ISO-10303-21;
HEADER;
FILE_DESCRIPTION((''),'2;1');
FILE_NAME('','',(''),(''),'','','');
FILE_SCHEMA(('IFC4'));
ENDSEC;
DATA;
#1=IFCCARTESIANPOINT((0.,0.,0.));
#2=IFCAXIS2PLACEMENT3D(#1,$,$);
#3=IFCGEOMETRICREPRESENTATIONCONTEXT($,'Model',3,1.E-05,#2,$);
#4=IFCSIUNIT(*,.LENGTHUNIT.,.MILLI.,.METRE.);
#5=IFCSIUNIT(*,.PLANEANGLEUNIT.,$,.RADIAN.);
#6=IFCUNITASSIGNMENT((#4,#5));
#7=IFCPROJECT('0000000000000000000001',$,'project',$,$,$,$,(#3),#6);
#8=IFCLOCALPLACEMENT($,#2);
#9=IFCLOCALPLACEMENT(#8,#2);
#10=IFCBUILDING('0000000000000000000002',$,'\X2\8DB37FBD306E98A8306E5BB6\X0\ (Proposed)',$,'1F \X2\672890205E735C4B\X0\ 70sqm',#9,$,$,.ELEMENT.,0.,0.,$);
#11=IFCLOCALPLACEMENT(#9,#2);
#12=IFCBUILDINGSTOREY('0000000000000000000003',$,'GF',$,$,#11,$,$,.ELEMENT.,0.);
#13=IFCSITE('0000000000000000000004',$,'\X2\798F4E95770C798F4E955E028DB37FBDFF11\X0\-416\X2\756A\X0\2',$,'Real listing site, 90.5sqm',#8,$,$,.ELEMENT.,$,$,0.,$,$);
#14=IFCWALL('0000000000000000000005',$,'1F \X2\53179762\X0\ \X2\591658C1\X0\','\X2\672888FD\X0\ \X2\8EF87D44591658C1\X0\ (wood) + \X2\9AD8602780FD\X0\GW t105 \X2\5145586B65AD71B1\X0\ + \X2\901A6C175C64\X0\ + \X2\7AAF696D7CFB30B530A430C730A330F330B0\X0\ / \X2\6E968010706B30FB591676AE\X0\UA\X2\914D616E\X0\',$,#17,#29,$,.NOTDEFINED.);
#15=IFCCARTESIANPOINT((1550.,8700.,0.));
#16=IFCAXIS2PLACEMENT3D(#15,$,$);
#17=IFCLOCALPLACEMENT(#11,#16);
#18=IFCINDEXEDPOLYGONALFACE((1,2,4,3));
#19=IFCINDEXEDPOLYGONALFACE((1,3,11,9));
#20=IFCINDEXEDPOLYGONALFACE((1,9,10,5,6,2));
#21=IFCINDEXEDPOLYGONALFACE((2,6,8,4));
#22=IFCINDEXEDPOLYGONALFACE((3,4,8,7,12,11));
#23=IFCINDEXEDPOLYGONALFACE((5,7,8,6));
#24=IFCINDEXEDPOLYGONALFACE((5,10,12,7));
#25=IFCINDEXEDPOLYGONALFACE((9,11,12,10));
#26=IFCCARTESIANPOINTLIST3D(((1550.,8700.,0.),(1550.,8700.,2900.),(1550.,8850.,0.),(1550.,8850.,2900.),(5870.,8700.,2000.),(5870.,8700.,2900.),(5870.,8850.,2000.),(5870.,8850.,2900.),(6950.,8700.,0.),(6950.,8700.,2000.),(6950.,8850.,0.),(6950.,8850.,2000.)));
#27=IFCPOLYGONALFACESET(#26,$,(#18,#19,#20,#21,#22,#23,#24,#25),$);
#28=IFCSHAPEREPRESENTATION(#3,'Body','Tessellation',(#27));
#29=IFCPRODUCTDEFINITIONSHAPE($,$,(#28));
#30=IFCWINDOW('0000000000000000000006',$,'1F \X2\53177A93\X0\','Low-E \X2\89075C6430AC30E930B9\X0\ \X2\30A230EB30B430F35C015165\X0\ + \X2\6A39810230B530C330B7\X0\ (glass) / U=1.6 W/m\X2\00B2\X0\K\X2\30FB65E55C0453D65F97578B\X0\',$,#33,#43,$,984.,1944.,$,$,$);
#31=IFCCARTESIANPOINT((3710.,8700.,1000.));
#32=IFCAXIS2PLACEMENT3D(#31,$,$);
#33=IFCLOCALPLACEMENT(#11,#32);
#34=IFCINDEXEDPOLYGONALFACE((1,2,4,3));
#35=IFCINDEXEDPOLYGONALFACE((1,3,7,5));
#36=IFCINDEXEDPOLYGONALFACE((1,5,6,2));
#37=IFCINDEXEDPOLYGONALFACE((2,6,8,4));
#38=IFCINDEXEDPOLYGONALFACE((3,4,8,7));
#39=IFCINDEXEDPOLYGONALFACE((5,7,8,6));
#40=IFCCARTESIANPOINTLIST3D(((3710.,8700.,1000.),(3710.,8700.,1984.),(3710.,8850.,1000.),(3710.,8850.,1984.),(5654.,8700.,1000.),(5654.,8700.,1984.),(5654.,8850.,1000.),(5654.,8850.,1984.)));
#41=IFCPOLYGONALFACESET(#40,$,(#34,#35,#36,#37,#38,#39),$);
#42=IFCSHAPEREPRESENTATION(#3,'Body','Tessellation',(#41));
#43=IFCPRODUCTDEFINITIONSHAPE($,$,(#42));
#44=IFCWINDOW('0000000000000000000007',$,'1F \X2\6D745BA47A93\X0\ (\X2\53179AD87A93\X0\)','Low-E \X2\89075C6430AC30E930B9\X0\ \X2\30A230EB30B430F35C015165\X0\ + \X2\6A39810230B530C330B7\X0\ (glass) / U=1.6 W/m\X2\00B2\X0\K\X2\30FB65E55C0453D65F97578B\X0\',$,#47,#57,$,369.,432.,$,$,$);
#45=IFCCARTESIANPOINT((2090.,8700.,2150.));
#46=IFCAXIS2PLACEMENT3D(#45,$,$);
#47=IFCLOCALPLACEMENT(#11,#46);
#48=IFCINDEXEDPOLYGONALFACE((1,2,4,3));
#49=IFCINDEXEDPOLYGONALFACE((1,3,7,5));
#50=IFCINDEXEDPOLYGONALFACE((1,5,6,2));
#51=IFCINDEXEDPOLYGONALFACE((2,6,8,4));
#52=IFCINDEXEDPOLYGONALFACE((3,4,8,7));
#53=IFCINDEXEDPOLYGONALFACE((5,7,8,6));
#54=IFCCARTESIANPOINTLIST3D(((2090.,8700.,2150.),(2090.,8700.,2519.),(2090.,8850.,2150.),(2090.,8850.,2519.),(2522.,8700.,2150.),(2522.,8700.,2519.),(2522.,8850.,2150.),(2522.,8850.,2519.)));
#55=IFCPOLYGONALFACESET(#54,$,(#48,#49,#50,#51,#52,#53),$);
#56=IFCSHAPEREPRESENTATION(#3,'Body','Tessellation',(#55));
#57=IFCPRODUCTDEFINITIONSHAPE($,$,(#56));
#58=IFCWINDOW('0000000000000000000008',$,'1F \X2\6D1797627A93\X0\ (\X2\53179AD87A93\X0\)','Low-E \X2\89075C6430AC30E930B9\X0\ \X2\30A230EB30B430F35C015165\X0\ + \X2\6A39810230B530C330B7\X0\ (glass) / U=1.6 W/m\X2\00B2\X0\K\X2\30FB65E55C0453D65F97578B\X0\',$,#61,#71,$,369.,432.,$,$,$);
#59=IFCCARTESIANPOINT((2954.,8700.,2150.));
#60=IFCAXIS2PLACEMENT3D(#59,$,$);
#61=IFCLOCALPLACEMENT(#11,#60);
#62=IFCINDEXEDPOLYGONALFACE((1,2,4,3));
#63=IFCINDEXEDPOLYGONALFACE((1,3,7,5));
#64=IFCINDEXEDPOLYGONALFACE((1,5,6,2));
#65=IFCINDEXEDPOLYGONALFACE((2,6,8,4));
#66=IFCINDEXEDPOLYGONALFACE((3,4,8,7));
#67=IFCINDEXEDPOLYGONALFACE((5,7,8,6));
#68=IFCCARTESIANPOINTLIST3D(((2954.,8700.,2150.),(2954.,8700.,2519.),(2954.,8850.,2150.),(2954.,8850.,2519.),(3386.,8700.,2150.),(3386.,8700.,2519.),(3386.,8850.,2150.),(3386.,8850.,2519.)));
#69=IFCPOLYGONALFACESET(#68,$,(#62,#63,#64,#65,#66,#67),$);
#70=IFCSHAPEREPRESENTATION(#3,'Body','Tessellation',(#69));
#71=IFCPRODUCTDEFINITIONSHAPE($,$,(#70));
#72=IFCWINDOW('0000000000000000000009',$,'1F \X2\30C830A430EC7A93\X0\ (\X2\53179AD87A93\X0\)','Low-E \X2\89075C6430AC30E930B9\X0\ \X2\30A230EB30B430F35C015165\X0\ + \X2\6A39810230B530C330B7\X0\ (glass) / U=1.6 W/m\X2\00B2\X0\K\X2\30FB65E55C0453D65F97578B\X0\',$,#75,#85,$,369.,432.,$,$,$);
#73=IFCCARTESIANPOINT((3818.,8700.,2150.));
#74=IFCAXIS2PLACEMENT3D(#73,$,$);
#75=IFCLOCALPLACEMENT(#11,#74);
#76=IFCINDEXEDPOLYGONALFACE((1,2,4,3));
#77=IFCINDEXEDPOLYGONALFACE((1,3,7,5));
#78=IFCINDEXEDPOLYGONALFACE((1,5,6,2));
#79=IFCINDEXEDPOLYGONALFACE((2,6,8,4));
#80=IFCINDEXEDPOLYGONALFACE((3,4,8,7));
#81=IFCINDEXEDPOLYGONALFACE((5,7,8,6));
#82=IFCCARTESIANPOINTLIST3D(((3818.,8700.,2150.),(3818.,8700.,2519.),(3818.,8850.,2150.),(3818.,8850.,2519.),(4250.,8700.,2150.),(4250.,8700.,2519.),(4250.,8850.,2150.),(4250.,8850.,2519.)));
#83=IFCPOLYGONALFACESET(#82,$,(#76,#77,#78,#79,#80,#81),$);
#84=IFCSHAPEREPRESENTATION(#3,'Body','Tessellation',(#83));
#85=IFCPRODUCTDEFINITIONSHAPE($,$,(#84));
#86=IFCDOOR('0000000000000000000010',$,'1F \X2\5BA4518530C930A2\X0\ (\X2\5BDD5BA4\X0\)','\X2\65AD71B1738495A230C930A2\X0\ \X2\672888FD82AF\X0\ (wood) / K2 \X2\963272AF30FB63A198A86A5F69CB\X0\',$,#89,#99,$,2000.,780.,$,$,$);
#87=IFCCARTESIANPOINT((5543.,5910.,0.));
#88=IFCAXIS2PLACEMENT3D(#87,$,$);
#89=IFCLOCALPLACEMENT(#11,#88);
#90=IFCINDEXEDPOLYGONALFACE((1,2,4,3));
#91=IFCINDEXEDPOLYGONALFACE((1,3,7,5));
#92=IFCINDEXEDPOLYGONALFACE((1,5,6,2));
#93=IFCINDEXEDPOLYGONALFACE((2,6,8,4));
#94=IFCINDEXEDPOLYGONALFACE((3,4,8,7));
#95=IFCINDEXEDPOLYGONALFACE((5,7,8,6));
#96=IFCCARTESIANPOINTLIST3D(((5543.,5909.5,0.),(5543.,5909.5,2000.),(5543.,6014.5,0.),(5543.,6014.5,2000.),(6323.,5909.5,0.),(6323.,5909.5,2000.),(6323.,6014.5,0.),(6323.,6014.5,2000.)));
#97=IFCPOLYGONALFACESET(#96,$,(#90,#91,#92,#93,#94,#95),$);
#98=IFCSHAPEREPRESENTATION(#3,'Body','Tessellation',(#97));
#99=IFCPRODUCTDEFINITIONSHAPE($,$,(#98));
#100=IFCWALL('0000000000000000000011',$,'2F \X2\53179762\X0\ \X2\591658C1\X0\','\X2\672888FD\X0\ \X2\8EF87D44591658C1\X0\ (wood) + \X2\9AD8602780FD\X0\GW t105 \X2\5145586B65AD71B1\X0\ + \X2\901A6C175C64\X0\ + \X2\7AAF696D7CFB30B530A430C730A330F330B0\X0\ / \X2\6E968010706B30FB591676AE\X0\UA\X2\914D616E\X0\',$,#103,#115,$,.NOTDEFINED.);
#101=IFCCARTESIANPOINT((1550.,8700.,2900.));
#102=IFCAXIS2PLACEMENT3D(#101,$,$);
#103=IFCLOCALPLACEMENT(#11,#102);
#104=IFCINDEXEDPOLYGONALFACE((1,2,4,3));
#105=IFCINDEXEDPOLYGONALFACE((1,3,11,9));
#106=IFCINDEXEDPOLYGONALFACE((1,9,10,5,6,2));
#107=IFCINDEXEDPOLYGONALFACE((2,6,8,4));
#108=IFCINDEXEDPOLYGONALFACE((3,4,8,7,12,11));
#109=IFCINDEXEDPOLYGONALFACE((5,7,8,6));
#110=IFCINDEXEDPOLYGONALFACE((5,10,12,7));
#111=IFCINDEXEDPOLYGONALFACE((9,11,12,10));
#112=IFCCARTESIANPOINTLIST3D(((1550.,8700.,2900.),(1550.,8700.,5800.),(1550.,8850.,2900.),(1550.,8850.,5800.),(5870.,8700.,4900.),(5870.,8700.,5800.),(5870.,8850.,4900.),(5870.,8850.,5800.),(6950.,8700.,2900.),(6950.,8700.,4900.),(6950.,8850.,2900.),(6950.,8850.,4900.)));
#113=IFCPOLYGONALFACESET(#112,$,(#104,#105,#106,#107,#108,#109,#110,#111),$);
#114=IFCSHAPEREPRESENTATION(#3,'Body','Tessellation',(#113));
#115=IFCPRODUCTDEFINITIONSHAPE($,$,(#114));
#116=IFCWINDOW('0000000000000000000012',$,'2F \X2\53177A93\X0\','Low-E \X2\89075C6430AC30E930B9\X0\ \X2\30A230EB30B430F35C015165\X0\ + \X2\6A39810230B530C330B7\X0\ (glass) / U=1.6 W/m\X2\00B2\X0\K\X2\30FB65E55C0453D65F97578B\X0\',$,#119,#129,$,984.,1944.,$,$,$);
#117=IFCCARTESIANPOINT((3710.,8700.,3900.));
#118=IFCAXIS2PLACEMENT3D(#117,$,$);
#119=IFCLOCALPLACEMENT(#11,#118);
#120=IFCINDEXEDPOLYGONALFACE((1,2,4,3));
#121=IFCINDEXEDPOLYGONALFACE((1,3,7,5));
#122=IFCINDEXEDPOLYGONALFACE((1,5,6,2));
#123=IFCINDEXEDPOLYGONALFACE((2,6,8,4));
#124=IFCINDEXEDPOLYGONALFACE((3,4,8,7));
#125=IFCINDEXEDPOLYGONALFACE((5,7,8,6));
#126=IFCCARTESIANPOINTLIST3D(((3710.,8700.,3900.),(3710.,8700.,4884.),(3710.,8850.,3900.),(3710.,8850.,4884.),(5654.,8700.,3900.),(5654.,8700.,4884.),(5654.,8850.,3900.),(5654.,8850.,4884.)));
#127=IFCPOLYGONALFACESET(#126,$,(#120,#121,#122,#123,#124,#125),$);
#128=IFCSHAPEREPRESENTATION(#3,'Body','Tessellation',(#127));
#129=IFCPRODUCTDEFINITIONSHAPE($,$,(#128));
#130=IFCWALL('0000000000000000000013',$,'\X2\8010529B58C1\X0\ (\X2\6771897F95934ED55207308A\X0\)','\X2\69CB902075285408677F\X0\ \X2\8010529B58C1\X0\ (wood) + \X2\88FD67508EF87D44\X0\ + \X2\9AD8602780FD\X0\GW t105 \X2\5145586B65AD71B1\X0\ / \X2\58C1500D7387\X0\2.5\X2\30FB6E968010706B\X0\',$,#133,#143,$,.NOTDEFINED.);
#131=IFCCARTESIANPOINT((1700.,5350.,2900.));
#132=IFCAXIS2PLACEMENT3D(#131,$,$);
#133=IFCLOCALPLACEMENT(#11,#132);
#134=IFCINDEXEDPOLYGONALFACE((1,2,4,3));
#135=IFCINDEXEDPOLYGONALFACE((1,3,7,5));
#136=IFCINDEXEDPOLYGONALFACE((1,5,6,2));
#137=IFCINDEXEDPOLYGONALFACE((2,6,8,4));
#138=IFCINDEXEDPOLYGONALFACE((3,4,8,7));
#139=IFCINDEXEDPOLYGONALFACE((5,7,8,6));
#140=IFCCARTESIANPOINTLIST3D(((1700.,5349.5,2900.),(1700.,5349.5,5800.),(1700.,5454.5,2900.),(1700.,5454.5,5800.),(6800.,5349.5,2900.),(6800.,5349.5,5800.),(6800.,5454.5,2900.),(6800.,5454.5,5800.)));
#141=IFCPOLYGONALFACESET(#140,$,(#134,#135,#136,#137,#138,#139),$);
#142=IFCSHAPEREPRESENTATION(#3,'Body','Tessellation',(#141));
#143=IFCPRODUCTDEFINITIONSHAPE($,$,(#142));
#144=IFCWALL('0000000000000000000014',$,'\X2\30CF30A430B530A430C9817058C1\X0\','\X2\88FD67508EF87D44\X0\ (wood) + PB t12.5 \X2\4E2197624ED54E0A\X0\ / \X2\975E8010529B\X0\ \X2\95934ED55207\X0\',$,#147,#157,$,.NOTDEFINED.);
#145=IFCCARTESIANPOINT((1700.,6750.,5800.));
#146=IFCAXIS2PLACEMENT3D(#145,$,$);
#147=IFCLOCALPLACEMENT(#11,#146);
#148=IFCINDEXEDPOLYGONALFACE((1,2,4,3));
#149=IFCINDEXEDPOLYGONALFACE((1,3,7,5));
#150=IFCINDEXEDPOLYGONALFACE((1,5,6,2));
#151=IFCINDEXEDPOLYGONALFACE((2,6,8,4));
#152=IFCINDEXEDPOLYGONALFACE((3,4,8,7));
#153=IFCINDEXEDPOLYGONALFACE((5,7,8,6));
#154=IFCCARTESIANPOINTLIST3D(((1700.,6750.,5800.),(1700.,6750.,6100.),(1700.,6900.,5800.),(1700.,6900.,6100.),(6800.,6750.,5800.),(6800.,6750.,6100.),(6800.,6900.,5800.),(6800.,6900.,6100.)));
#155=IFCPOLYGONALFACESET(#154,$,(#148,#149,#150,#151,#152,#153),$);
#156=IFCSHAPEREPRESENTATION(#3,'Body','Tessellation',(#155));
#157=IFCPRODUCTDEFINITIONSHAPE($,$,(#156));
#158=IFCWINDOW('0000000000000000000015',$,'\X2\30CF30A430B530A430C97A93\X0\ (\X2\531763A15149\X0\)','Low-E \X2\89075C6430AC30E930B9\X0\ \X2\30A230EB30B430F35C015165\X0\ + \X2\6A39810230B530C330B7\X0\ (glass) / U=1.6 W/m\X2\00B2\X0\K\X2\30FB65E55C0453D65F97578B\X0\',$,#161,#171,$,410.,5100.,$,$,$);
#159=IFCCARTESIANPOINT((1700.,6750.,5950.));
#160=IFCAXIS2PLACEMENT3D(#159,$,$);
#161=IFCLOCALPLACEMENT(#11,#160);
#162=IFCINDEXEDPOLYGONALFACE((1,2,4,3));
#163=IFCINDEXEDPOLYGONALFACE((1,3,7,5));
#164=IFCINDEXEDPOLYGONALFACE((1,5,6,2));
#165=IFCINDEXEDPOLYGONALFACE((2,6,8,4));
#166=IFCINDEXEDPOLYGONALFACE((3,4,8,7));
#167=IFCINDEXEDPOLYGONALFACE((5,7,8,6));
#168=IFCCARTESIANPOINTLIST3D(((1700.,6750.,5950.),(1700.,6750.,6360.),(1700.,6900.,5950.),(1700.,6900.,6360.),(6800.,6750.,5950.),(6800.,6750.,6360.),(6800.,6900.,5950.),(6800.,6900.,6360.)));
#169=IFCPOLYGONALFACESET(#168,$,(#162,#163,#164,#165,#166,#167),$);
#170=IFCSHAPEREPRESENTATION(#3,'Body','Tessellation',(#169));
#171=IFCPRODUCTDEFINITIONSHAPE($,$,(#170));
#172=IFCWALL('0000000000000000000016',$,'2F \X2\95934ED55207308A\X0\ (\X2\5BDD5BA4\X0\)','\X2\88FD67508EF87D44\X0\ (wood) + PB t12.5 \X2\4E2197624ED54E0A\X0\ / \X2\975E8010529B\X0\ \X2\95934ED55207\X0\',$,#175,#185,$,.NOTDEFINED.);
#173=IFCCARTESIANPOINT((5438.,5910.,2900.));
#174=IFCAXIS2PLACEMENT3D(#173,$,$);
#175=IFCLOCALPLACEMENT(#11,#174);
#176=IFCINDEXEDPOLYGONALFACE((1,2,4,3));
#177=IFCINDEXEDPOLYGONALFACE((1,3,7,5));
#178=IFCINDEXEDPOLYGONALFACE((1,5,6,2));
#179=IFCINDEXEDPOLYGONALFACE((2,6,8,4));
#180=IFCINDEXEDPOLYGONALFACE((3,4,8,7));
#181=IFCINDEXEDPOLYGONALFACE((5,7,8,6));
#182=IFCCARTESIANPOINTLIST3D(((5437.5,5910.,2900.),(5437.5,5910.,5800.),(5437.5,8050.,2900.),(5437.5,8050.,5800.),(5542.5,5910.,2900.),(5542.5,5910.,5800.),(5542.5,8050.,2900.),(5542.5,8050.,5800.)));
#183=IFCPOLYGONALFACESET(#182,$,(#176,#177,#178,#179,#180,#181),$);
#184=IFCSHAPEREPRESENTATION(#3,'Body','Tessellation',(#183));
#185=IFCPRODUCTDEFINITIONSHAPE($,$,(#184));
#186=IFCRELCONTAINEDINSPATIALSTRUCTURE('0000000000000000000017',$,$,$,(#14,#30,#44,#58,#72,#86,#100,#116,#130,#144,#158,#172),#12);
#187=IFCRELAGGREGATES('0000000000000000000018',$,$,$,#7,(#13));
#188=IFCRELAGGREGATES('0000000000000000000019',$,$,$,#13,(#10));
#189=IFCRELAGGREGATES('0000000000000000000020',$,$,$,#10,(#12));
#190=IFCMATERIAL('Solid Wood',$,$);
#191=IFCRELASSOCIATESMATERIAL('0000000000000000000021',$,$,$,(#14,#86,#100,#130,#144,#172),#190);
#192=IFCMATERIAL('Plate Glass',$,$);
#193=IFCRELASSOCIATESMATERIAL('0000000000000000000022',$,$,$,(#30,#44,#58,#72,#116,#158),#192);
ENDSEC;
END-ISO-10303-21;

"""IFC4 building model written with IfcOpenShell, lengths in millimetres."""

from ifc_helpers import new_model, si_unit, frame, frame_2d, origin, place, context, project, spatial, rectangle, extrude, material, element, fill, save


model = new_model("IFC4")

# Units and contexts
model_context = context("Model", 3, precision=1e-05, world=origin())
ifc_project = project(units=[si_unit("LENGTHUNIT", "METRE", prefix="MILLI"), si_unit("PLANEANGLEUNIT", "RADIAN")], contexts=[model_context])

# Site, building, storey
site_placement = place(None, origin())
site = spatial("IfcSite", under=ifc_project, at=site_placement, Name="福井県福井市足羽１-416番2", ObjectType="Real listing site, 90.5sqm", CompositionType="ELEMENT", RefElevation=0.0)
building_placement = place(site_placement, origin())
building = spatial("IfcBuilding", under=site, at=building_placement, Name="足羽の風の家 (Proposed)", ObjectType="1F 木造平屋 70sqm", CompositionType="ELEMENT", ElevationOfRefHeight=0.0, ElevationOfTerrain=0.0)
storey_placement = place(building_placement, origin())
storey = spatial("IfcBuildingStorey", under=building, at=storey_placement, Name="GF", CompositionType="ELEMENT", Elevation=0.0)

# Wall, openings, windows
ifc_material_1 = material(Name="Solid Wood")
wall_1_placement = place(storey_placement, frame((1550.0, 8700.0, 0.0)))
wall_1 = element("IfcWall", 1, at=wall_1_placement, inside=storey, material=ifc_material_1, Name="1F 北面 外壁", Description="木製 軸組外壁 (wood) + 高性能GW t105 充填断熱 + 通気層 + 窯業系サイディング / 準耐火・外皮UA配慮", PredefinedType="NOTDEFINED", context=model_context, shape_type="SweptSolid", body=[
    extrude(rectangle(XDim=5400.0, YDim=150.0, at=frame_2d((2700.0, 75.0))), frame((1550.0, 8700.0, 0.0)), (0.0, 0.0, 1.0), 2900.0),
])
opening_1_placement = place(storey_placement, frame((3710.0, 8700.0, 1000.0)))
opening_1 = element("IfcOpeningElement", 2, at=opening_1_placement, cuts=wall_1, PredefinedType="NOTDEFINED", context=model_context, shape_type="SweptSolid", body=[
    extrude(rectangle(XDim=1944.0, YDim=150.0, at=frame_2d((972.0, 75.0))), frame((3710.0, 8700.0, 1000.0)), (0.0, 0.0, 1.0), 984.0),
])
opening_2_placement = place(storey_placement, frame((2090.0, 8700.0, 2150.0)))
opening_2 = element("IfcOpeningElement", 3, at=opening_2_placement, cuts=wall_1, PredefinedType="NOTDEFINED", context=model_context, shape_type="SweptSolid", body=[
    extrude(rectangle(XDim=432.0, YDim=150.0, at=frame_2d((216.0, 75.0))), frame((2090.0, 8700.0, 2150.0)), (0.0, 0.0, 1.0), 369.0),
])
opening_3_placement = place(storey_placement, frame((2954.0, 8700.0, 2150.0)))
opening_3 = element("IfcOpeningElement", 4, at=opening_3_placement, cuts=wall_1, PredefinedType="NOTDEFINED", context=model_context, shape_type="SweptSolid", body=[
    extrude(rectangle(XDim=432.0, YDim=150.0, at=frame_2d((216.0, 75.0))), frame((2954.0, 8700.0, 2150.0)), (0.0, 0.0, 1.0), 369.0),
])
opening_4_placement = place(storey_placement, frame((3818.0, 8700.0, 2150.0)))
opening_4 = element("IfcOpeningElement", 5, at=opening_4_placement, cuts=wall_1, PredefinedType="NOTDEFINED", context=model_context, shape_type="SweptSolid", body=[
    extrude(rectangle(XDim=432.0, YDim=150.0, at=frame_2d((216.0, 75.0))), frame((3818.0, 8700.0, 2150.0)), (0.0, 0.0, 1.0), 369.0),
])
ifc_material_2 = material(Name="Plate Glass")
window_1_placement = place(storey_placement, frame((3710.0, 8700.0, 1000.0)))
window_1 = element("IfcWindow", 6, at=window_1_placement, inside=storey, material=ifc_material_2, Name="1F 北窓", Description="Low-E 複層ガラス アルゴン封入 + 樹脂サッシ (glass) / U=1.6 W/m²K・日射取得型", OverallHeight=984.0, OverallWidth=1944.0, context=model_context, shape_type="SweptSolid", body=[
    extrude(rectangle(XDim=1944.0, YDim=150.0, at=frame_2d((972.0, 75.0))), frame((3710.0, 8700.0, 1000.0)), (0.0, 0.0, 1.0), 984.0),
])
fill(opening_1, window_1)
window_2_placement = place(storey_placement, frame((2090.0, 8700.0, 2150.0)))
window_2 = element("IfcWindow", 7, at=window_2_placement, inside=storey, material=ifc_material_2, Name="1F 浴室窓 (北高窓)", Description="Low-E 複層ガラス アルゴン封入 + 樹脂サッシ (glass) / U=1.6 W/m²K・日射取得型", OverallHeight=369.0, OverallWidth=432.0, context=model_context, shape_type="SweptSolid", body=[
    extrude(rectangle(XDim=432.0, YDim=150.0, at=frame_2d((216.0, 75.0))), frame((2090.0, 8700.0, 2150.0)), (0.0, 0.0, 1.0), 369.0),
])
fill(opening_2, window_2)
window_3_placement = place(storey_placement, frame((2954.0, 8700.0, 2150.0)))
window_3 = element("IfcWindow", 8, at=window_3_placement, inside=storey, material=ifc_material_2, Name="1F 洗面窓 (北高窓)", Description="Low-E 複層ガラス アルゴン封入 + 樹脂サッシ (glass) / U=1.6 W/m²K・日射取得型", OverallHeight=369.0, OverallWidth=432.0, context=model_context, shape_type="SweptSolid", body=[
    extrude(rectangle(XDim=432.0, YDim=150.0, at=frame_2d((216.0, 75.0))), frame((2954.0, 8700.0, 2150.0)), (0.0, 0.0, 1.0), 369.0),
])
fill(opening_3, window_3)
window_4_placement = place(storey_placement, frame((3818.0, 8700.0, 2150.0)))
window_4 = element("IfcWindow", 9, at=window_4_placement, inside=storey, material=ifc_material_2, Name="1F トイレ窓 (北高窓)", Description="Low-E 複層ガラス アルゴン封入 + 樹脂サッシ (glass) / U=1.6 W/m²K・日射取得型", OverallHeight=369.0, OverallWidth=432.0, context=model_context, shape_type="SweptSolid", body=[
    extrude(rectangle(XDim=432.0, YDim=150.0, at=frame_2d((216.0, 75.0))), frame((3818.0, 8700.0, 2150.0)), (0.0, 0.0, 1.0), 369.0),
])
fill(opening_4, window_4)

# Door
door_1_placement = place(storey_placement, frame((5543.0, 5910.0, 0.0)))
element("IfcDoor", 10, at=door_1_placement, inside=storey, material=ifc_material_1, Name="1F 室内ドア (寝室)", Description="断熱玄関ドア 木製芯 (wood) / K2 防犯・採風機構", OverallHeight=2000.0, OverallWidth=780.0, context=model_context, shape_type="SweptSolid", body=[
    extrude(rectangle(XDim=780.0, YDim=105.0, at=frame_2d((390.0, 52.0))), frame((5543.0, 5910.0, 0.0)), (0.0, 0.0, 1.0), 2000.0),
])

# Wall, opening, window
wall_2_placement = place(storey_placement, frame((1550.0, 8700.0, 2900.0)))
wall_2 = element("IfcWall", 11, at=wall_2_placement, inside=storey, material=ifc_material_1, Name="2F 北面 外壁", Description="木製 軸組外壁 (wood) + 高性能GW t105 充填断熱 + 通気層 + 窯業系サイディング / 準耐火・外皮UA配慮", PredefinedType="NOTDEFINED", context=model_context, shape_type="SweptSolid", body=[
    extrude(rectangle(XDim=5400.0, YDim=150.0, at=frame_2d((2700.0, 75.0))), frame((1550.0, 8700.0, 2900.0)), (0.0, 0.0, 1.0), 2900.0),
])
opening_5_placement = place(storey_placement, frame((3710.0, 8700.0, 3900.0)))
opening_5 = element("IfcOpeningElement", 12, at=opening_5_placement, cuts=wall_2, PredefinedType="NOTDEFINED", context=model_context, shape_type="SweptSolid", body=[
    extrude(rectangle(XDim=1944.0, YDim=150.0, at=frame_2d((972.0, 75.0))), frame((3710.0, 8700.0, 3900.0)), (0.0, 0.0, 1.0), 984.0),
])
window_5_placement = place(storey_placement, frame((3710.0, 8700.0, 3900.0)))
window_5 = element("IfcWindow", 13, at=window_5_placement, inside=storey, material=ifc_material_2, Name="2F 北窓", Description="Low-E 複層ガラス アルゴン封入 + 樹脂サッシ (glass) / U=1.6 W/m²K・日射取得型", OverallHeight=984.0, OverallWidth=1944.0, context=model_context, shape_type="SweptSolid", body=[
    extrude(rectangle(XDim=1944.0, YDim=150.0, at=frame_2d((972.0, 75.0))), frame((3710.0, 8700.0, 3900.0)), (0.0, 0.0, 1.0), 984.0),
])
fill(opening_5, window_5)

# Wall
wall_3_placement = place(storey_placement, frame((1700.0, 5350.0, 2900.0)))
element("IfcWall", 14, at=wall_3_placement, inside=storey, material=ifc_material_1, Name="耐力壁 (東西間仕切り)", Description="構造用合板 耐力壁 (wood) + 製材軸組 + 高性能GW t105 充填断熱 / 壁倍率2.5・準耐火", PredefinedType="NOTDEFINED", context=model_context, shape_type="SweptSolid", body=[
    extrude(rectangle(XDim=5100.0, YDim=105.0, at=frame_2d((2550.0, 52.0))), frame((1700.0, 5350.0, 2900.0)), (0.0, 0.0, 1.0), 2900.0),
])

# Wall, opening, window
wall_4_placement = place(storey_placement, frame((1700.0, 6750.0, 5800.0)))
wall_4 = element("IfcWall", 15, at=wall_4_placement, inside=storey, material=ifc_material_1, Name="ハイサイド腰壁", Description="製材軸組 (wood) + PB t12.5 両面仕上 / 非耐力 間仕切", PredefinedType="NOTDEFINED", context=model_context, shape_type="SweptSolid", body=[
    extrude(rectangle(XDim=5100.0, YDim=150.0, at=frame_2d((2550.0, 75.0))), frame((1700.0, 6750.0, 5800.0)), (0.0, 0.0, 1.0), 700.0),
])
opening_6_placement = place(storey_placement, frame((1700.0, 6750.0, 5950.0)))
opening_6 = element("IfcOpeningElement", 16, at=opening_6_placement, cuts=wall_4, PredefinedType="NOTDEFINED", context=model_context, shape_type="SweptSolid", body=[
    extrude(rectangle(XDim=5100.0, YDim=150.0, at=frame_2d((2550.0, 75.0))), frame((1700.0, 6750.0, 5950.0)), (0.0, 0.0, 1.0), 410.0),
])
window_6_placement = place(storey_placement, frame((1700.0, 6750.0, 5950.0)))
window_6 = element("IfcWindow", 17, at=window_6_placement, inside=storey, material=ifc_material_2, Name="ハイサイド窓 (北採光)", Description="Low-E 複層ガラス アルゴン封入 + 樹脂サッシ (glass) / U=1.6 W/m²K・日射取得型", OverallHeight=410.0, OverallWidth=5100.0, context=model_context, shape_type="SweptSolid", body=[
    extrude(rectangle(XDim=5100.0, YDim=150.0, at=frame_2d((2550.0, 75.0))), frame((1700.0, 6750.0, 5950.0)), (0.0, 0.0, 1.0), 410.0),
])
fill(opening_6, window_6)

# Wall
wall_5_placement = place(storey_placement, frame((5438.0, 5910.0, 2900.0)))
element("IfcWall", 18, at=wall_5_placement, inside=storey, material=ifc_material_1, Name="2F 間仕切り (寝室)", Description="製材軸組 (wood) + PB t12.5 両面仕上 / 非耐力 間仕切", PredefinedType="NOTDEFINED", context=model_context, shape_type="SweptSolid", body=[
    extrude(rectangle(XDim=105.0, YDim=2140.0, at=frame_2d((52.0, 1070.0))), frame((5438.0, 5910.0, 2900.0)), (0.0, 0.0, 1.0), 2900.0),
])

save(model, "model.ifc")
